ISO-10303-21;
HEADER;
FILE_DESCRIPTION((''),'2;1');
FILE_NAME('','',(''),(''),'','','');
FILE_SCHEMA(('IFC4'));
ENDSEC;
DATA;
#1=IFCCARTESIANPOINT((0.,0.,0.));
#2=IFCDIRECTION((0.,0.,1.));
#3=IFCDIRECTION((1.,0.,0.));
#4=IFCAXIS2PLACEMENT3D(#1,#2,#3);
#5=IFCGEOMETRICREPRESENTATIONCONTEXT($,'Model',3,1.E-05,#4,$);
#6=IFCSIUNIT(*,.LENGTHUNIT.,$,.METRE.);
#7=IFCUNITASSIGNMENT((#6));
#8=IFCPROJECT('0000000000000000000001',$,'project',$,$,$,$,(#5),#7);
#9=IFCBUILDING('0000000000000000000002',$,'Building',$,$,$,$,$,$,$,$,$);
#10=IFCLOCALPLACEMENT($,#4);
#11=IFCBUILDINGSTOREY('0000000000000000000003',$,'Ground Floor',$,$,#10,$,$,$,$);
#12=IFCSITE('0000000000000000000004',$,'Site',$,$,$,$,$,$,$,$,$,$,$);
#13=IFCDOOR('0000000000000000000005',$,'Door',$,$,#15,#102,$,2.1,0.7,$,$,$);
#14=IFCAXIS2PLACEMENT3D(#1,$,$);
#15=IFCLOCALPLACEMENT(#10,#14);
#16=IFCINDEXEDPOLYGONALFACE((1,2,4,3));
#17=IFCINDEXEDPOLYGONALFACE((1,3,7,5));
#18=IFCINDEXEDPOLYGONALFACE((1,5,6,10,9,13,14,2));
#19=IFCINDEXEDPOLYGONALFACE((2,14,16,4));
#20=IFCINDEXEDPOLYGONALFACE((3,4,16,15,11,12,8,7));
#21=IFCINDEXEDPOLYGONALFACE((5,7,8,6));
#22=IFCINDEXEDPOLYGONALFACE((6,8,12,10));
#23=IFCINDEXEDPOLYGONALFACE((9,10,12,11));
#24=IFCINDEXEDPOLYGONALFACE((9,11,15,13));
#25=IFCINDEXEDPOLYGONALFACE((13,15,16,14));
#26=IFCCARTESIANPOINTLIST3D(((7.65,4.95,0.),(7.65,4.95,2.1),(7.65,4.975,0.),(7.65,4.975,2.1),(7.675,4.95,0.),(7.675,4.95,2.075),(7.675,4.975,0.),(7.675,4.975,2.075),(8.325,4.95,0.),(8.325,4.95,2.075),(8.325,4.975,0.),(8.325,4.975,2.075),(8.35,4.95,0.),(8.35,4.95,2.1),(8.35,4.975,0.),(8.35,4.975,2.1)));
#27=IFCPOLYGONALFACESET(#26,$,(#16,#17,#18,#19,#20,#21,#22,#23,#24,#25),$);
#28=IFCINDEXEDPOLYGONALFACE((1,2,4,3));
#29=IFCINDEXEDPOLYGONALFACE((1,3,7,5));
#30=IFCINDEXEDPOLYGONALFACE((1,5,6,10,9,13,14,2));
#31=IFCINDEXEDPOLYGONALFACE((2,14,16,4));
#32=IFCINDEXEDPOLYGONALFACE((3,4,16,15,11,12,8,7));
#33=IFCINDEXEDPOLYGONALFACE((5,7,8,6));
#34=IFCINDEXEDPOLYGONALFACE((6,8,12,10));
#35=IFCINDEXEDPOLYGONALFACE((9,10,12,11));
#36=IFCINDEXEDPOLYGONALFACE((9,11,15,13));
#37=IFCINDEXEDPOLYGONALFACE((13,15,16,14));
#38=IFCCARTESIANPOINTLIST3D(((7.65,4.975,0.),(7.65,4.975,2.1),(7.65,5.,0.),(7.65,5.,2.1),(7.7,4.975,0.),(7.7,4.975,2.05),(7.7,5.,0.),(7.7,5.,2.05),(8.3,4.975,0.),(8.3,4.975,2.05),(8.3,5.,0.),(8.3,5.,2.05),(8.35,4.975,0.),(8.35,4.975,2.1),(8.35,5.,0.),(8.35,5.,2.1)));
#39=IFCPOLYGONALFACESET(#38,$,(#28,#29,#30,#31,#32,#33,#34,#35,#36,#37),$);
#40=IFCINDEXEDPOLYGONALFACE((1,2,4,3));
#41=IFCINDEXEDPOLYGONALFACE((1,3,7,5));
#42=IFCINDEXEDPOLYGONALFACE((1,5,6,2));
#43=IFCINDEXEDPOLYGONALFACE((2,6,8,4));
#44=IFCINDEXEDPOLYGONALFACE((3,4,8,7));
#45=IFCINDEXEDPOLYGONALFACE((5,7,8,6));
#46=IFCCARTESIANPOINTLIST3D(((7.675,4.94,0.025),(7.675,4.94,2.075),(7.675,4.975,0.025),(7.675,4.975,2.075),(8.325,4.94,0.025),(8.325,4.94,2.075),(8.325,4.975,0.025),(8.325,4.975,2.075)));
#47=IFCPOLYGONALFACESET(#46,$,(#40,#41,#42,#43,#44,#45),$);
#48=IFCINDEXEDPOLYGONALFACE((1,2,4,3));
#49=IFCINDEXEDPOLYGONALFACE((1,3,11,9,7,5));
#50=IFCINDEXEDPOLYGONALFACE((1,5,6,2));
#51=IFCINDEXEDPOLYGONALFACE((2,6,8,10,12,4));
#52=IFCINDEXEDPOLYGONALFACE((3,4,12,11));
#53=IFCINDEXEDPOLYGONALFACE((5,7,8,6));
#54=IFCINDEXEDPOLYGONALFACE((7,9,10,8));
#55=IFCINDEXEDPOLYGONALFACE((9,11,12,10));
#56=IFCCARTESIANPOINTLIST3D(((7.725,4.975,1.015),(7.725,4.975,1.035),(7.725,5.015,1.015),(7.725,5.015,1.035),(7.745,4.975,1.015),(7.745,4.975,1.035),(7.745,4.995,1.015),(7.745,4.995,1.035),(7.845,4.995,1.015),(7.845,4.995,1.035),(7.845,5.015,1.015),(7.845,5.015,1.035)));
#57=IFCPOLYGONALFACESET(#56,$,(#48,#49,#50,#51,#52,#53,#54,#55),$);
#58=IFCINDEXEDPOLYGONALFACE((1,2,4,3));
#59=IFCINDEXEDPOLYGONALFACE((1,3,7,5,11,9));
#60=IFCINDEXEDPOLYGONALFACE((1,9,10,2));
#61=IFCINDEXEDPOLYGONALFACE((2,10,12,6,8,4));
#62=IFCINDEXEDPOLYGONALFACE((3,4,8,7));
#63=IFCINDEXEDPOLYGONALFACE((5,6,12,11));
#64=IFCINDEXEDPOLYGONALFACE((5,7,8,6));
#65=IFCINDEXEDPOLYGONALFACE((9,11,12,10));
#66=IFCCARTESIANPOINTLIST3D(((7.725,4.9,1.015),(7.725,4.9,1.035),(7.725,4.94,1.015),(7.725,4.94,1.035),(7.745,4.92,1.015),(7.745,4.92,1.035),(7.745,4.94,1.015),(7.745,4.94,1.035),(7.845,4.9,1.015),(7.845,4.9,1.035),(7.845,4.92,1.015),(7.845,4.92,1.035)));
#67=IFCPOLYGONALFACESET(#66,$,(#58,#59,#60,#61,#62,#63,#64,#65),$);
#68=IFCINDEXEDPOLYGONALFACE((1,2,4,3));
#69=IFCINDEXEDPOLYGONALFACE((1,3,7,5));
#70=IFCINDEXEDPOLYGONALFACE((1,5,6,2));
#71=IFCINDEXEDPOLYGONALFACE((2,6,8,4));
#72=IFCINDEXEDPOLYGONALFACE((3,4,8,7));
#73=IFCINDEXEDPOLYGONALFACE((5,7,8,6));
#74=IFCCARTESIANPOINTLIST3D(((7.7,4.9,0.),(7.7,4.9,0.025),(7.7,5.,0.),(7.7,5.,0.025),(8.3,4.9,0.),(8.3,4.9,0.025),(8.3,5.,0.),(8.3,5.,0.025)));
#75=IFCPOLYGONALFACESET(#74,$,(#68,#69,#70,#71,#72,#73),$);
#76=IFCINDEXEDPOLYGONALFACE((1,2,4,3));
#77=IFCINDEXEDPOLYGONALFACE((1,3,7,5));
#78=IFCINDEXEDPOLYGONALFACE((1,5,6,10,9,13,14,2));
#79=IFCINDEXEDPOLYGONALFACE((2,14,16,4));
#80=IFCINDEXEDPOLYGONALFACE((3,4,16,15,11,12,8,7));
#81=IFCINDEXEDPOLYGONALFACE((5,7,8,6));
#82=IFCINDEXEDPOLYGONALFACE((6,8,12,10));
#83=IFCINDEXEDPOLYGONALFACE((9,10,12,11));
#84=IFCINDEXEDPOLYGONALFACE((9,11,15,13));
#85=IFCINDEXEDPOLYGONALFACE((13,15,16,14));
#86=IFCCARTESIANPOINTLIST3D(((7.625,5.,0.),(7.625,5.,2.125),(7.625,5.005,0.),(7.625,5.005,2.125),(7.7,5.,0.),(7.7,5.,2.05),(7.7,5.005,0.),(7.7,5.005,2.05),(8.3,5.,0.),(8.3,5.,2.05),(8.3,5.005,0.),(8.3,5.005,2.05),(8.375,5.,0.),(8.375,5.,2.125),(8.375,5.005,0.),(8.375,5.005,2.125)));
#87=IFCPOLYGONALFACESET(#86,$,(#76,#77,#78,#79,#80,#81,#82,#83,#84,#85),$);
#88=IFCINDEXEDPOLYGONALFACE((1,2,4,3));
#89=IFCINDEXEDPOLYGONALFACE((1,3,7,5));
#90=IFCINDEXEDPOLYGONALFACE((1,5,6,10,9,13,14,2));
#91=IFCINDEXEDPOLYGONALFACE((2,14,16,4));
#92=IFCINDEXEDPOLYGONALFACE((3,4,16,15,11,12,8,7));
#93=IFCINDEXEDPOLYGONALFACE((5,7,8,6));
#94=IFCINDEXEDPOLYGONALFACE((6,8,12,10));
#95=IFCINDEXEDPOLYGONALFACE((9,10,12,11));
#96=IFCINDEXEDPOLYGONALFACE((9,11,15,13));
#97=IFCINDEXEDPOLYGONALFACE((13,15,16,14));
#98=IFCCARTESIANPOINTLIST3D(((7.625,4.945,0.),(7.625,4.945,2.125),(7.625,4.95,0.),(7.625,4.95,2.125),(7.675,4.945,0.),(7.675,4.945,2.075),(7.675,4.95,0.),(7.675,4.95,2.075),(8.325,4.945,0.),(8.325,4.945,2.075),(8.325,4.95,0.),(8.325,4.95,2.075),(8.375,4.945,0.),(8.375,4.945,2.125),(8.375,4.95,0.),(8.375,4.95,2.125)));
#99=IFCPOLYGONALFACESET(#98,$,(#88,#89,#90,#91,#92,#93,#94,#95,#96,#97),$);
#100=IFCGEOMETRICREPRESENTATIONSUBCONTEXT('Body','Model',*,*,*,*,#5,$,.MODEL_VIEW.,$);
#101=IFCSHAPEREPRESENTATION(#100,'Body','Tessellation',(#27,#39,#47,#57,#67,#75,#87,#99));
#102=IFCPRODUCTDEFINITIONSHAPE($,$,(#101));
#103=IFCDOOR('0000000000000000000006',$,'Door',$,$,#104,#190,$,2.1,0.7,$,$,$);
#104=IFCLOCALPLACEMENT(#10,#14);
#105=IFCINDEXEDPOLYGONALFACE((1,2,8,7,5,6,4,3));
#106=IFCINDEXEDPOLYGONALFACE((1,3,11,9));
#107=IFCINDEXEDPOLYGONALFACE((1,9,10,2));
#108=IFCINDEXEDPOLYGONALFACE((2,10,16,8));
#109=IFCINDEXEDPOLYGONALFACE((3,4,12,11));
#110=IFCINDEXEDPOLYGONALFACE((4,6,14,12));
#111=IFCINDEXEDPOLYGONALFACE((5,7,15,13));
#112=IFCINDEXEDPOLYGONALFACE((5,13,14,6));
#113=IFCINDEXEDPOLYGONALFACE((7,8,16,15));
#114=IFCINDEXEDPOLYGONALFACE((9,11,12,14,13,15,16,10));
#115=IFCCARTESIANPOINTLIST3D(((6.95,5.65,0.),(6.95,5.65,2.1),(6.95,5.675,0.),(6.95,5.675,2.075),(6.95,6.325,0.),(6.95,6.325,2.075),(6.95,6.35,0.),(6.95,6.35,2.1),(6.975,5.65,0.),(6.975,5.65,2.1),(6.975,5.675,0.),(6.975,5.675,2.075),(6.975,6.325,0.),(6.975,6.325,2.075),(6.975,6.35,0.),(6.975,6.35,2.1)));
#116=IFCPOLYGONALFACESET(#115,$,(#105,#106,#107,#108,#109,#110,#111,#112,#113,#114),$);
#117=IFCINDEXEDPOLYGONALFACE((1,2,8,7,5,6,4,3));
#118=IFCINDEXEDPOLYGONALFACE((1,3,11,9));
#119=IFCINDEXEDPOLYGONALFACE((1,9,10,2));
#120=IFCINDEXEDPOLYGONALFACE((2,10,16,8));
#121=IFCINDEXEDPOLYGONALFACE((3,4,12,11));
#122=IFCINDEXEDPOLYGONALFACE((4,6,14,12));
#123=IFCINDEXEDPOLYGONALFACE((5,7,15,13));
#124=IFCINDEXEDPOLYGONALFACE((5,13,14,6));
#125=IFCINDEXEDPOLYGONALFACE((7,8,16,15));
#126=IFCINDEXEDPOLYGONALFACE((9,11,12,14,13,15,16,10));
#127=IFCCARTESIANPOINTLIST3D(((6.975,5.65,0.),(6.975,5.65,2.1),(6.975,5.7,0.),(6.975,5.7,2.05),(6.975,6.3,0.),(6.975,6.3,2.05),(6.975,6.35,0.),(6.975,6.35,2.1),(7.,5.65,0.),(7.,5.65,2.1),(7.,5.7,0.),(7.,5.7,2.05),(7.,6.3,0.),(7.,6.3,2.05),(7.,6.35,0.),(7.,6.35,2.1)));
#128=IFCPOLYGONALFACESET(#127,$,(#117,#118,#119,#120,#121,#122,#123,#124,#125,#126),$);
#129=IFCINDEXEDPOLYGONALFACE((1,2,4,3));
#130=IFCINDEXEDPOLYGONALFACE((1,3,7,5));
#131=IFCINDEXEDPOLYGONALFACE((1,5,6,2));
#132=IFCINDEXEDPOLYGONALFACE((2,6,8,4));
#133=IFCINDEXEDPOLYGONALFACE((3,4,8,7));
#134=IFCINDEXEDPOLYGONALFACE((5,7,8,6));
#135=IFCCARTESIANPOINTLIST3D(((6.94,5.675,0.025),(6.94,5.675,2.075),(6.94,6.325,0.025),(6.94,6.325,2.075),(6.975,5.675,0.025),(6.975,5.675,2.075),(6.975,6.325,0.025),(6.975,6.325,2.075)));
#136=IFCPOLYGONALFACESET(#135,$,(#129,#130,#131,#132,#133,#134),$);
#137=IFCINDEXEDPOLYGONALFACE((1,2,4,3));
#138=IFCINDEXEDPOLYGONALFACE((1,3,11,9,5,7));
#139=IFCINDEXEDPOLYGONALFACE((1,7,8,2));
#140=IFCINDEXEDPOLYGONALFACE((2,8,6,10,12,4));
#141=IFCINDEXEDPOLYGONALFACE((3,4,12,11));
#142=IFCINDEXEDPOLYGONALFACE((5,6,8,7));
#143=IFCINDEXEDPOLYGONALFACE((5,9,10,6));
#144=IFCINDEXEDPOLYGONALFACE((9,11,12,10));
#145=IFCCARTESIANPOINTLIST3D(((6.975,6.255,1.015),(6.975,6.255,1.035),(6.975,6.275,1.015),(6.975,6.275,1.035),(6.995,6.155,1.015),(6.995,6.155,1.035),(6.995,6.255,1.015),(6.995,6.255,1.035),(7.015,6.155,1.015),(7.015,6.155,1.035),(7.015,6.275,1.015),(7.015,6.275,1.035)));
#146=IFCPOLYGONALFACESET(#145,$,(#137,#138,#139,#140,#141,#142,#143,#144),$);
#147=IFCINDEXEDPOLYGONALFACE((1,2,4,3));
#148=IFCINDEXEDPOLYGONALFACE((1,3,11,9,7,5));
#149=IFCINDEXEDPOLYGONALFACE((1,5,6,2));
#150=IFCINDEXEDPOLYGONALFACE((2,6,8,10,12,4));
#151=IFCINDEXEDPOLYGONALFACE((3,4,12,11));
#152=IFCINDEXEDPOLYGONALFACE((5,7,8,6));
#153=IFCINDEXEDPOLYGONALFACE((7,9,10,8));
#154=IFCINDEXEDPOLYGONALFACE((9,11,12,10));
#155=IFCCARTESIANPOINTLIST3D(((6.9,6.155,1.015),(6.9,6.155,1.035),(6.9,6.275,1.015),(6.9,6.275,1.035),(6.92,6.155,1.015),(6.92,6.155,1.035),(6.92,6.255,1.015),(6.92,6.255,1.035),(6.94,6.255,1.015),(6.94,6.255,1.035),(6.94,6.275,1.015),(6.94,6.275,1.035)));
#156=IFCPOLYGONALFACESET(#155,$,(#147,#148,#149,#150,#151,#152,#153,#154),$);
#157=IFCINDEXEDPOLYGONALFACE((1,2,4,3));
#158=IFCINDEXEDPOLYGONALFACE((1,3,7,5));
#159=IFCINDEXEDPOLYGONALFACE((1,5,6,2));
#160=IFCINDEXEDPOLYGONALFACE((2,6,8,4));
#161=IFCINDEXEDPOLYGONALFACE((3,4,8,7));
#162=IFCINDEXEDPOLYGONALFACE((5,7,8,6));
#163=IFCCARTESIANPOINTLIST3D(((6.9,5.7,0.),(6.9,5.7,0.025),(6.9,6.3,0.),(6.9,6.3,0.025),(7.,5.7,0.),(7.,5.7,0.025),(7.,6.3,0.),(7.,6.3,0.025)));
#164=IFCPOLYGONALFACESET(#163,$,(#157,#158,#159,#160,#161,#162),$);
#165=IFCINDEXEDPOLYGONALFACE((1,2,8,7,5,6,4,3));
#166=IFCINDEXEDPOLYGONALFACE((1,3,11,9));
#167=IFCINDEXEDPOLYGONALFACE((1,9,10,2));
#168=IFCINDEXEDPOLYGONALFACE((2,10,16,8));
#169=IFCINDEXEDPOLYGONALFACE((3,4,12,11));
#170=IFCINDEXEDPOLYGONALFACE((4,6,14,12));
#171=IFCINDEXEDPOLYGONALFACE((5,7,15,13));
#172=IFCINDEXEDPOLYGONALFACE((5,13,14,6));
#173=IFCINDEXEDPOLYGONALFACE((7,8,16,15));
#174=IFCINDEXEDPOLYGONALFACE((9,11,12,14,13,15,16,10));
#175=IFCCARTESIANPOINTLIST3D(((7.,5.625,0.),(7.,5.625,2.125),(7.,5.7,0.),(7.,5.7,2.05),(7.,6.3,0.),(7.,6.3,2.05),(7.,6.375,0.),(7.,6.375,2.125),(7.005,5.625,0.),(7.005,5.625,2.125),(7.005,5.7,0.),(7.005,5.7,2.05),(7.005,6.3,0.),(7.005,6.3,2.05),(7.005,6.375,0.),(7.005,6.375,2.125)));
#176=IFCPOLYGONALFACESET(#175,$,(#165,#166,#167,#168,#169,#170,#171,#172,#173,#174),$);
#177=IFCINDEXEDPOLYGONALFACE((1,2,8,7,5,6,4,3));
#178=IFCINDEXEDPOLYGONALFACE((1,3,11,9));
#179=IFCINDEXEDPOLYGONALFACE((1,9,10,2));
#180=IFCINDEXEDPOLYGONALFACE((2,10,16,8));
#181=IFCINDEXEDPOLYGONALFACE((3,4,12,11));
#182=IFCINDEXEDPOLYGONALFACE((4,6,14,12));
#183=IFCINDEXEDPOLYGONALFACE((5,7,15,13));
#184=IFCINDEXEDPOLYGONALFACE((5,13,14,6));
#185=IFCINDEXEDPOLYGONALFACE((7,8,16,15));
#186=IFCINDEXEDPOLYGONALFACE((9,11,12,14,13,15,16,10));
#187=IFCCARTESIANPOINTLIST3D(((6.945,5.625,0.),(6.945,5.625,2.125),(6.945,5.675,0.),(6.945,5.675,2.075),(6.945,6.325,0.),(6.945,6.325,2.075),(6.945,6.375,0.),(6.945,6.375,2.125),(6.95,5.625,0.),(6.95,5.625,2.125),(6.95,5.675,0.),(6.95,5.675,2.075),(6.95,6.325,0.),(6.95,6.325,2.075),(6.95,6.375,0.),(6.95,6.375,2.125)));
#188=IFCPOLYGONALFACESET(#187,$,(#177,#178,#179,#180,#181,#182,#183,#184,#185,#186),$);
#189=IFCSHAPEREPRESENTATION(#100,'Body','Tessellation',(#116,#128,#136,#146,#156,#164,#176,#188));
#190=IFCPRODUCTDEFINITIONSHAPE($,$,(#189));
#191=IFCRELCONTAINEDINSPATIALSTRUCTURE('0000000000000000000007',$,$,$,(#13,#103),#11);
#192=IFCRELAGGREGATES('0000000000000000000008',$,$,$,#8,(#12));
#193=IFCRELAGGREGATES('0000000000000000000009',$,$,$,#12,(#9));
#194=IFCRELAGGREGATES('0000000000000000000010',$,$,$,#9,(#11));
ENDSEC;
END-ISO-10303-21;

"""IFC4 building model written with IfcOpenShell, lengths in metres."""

from ifc_helpers import new_model, si_unit, frame, origin_with_axes, place, context, subcontext, project, spatial, line, indexed_curve, outline, extrude, element, save


model = new_model("IFC4")

# Units and contexts
model_context = context("Model", 3, precision=1e-05, world=origin_with_axes())
body_context = subcontext(model_context, "Body", "Model", "MODEL_VIEW")
ifc_project = project(units=[si_unit("LENGTHUNIT", "METRE")], contexts=[model_context])

# Site, building, storey
site = spatial("IfcSite", under=ifc_project, Name="Site")
building = spatial("IfcBuilding", under=site, Name="Building")
storey_placement = place(None, origin_with_axes())
storey = spatial("IfcBuildingStorey", under=building, at=storey_placement, Name="Ground Floor")

# Doors
door_1_placement = place(storey_placement, frame((8.35, 5.0, 0.0), z_axis=(0.0, 0.0, 1.0), x_axis=(-1.0, 0.0, 0.0)))
element("IfcDoor", 1, at=door_1_placement, inside=storey, Name="Door", OverallHeight=2.1, OverallWidth=0.7, context=body_context, shape_type="SweptSolid", body=[
    extrude(outline(indexed_curve([(0.0, 0.0), (0.0, 2.1), (0.7, 2.1), (0.7, 0.0), (0.675, 0.0), (0.675, 2.075), (0.025, 2.075), (0.025, 0.0)], segments=[line(1, 2, 3, 4, 5, 6, 7, 8, 1)])), frame((0.0, 0.025, 0.0), z_axis=(0.0, -1.0, 0.0), x_axis=(1.0, 0.0, 0.0)), (0.0, 0.0, -1.0), 0.025),
    extrude(outline(indexed_curve([(0.0, 0.0), (0.0, 2.1), (0.7, 2.1), (0.7, 0.0), (0.65, 0.0), (0.65, 2.05), (0.05, 2.05), (0.05, 0.0)], segments=[line(1, 2, 3, 4, 5, 6, 7, 8, 1)])), frame((0.0, 0.0, 0.0), z_axis=(0.0, -1.0, 0.0), x_axis=(1.0, 0.0, 0.0)), (0.0, 0.0, -1.0), 0.025),
    extrude(outline(indexed_curve([(0.0, 0.0), (0.65, 0.0), (0.65, 0.035), (0.0, 0.035)], segments=[line(1, 2, 3, 4, 1)])), frame((0.025, 0.025, 0.025), z_axis=(0.0, 0.0, 1.0), x_axis=(1.0, 0.0, 0.0)), (0.0, 0.0, 1.0), 2.05),
    extrude(outline(indexed_curve([(0.0, 0.0), (0.0, -0.04), (-0.12, -0.04), (-0.12, -0.02), (-0.02, -0.02), (-0.02, 0.0)], segments=[line(1, 2, 3, 4, 5, 6, 1)])), frame((0.625, 0.025, 1.015), z_axis=(0.0, 0.0, 1.0), x_axis=(1.0, 0.0, 0.0)), (0.0, 0.0, 1.0), 0.02),
    extrude(outline(indexed_curve([(0.0, 0.0), (0.0, 0.04), (-0.12, 0.04), (-0.12, 0.02), (-0.02, 0.02), (-0.02, 0.0)], segments=[line(1, 2, 3, 4, 5, 6, 1)])), frame((0.625, 0.06, 1.015), z_axis=(0.0, 0.0, 1.0), x_axis=(1.0, 0.0, 0.0)), (0.0, 0.0, 1.0), 0.02),
    extrude(outline(indexed_curve([(0.0, 0.0), (0.6, 0.0), (0.6, 0.1), (0.0, 0.1)], segments=[line(1, 2, 3, 4, 1)])), frame((0.05, 0.0, 0.0), z_axis=(0.0, 0.0, 1.0), x_axis=(1.0, 0.0, 0.0)), (0.0, 0.0, 1.0), 0.025),
    extrude(outline(indexed_curve([(0.0, 0.0), (0.0, 2.125), (0.75, 2.125), (0.75, 0.0), (0.675, 0.0), (0.675, 2.05), (0.075, 2.05), (0.075, 0.0)], segments=[line(1, 2, 3, 4, 5, 6, 7, 8, 1)])), frame((-0.025, -0.005, 0.0), z_axis=(0.0, -1.0, 0.0), x_axis=(1.0, 0.0, 0.0)), (0.0, 0.0, -1.0), 0.005),
    extrude(outline(indexed_curve([(0.0, 0.0), (0.0, 2.125), (0.75, 2.125), (0.75, 0.0), (0.7, 0.0), (0.7, 2.075), (0.05, 2.075), (0.05, 0.0)], segments=[line(1, 2, 3, 4, 5, 6, 7, 8, 1)])), frame((-0.025, 0.05, 0.0), z_axis=(0.0, -1.0, 0.0), x_axis=(1.0, 0.0, 0.0)), (0.0, 0.0, -1.0), 0.005),
])
door_2_placement = place(storey_placement, frame((7.0, 5.65, 0.0), z_axis=(0.0, 0.0, 1.0), x_axis=(0.0, 1.0, 0.0)))
element("IfcDoor", 2, at=door_2_placement, inside=storey, Name="Door", OverallHeight=2.1, OverallWidth=0.7, context=body_context, shape_type="SweptSolid", body=[
    extrude(outline(indexed_curve([(0.0, 0.0), (0.0, 2.1), (0.7, 2.1), (0.7, 0.0), (0.675, 0.0), (0.675, 2.075), (0.025, 2.075), (0.025, 0.0)], segments=[line(1, 2, 3, 4, 5, 6, 7, 8, 1)])), frame((0.0, 0.025, 0.0), z_axis=(0.0, -1.0, 0.0), x_axis=(1.0, 0.0, 0.0)), (0.0, 0.0, -1.0), 0.025),
    extrude(outline(indexed_curve([(0.0, 0.0), (0.0, 2.1), (0.7, 2.1), (0.7, 0.0), (0.65, 0.0), (0.65, 2.05), (0.05, 2.05), (0.05, 0.0)], segments=[line(1, 2, 3, 4, 5, 6, 7, 8, 1)])), frame((0.0, 0.0, 0.0), z_axis=(0.0, -1.0, 0.0), x_axis=(1.0, 0.0, 0.0)), (0.0, 0.0, -1.0), 0.025),
    extrude(outline(indexed_curve([(0.0, 0.0), (0.65, 0.0), (0.65, 0.035), (0.0, 0.035)], segments=[line(1, 2, 3, 4, 1)])), frame((0.025, 0.025, 0.025), z_axis=(0.0, 0.0, 1.0), x_axis=(1.0, 0.0, 0.0)), (0.0, 0.0, 1.0), 2.05),
    extrude(outline(indexed_curve([(0.0, 0.0), (0.0, -0.04), (-0.12, -0.04), (-0.12, -0.02), (-0.02, -0.02), (-0.02, 0.0)], segments=[line(1, 2, 3, 4, 5, 6, 1)])), frame((0.625, 0.025, 1.015), z_axis=(0.0, 0.0, 1.0), x_axis=(1.0, 0.0, 0.0)), (0.0, 0.0, 1.0), 0.02),
    extrude(outline(indexed_curve([(0.0, 0.0), (0.0, 0.04), (-0.12, 0.04), (-0.12, 0.02), (-0.02, 0.02), (-0.02, 0.0)], segments=[line(1, 2, 3, 4, 5, 6, 1)])), frame((0.625, 0.06, 1.015), z_axis=(0.0, 0.0, 1.0), x_axis=(1.0, 0.0, 0.0)), (0.0, 0.0, 1.0), 0.02),
    extrude(outline(indexed_curve([(0.0, 0.0), (0.6, 0.0), (0.6, 0.1), (0.0, 0.1)], segments=[line(1, 2, 3, 4, 1)])), frame((0.05, 0.0, 0.0), z_axis=(0.0, 0.0, 1.0), x_axis=(1.0, 0.0, 0.0)), (0.0, 0.0, 1.0), 0.025),
    extrude(outline(indexed_curve([(0.0, 0.0), (0.0, 2.125), (0.75, 2.125), (0.75, 0.0), (0.675, 0.0), (0.675, 2.05), (0.075, 2.05), (0.075, 0.0)], segments=[line(1, 2, 3, 4, 5, 6, 7, 8, 1)])), frame((-0.025, -0.005, 0.0), z_axis=(0.0, -1.0, 0.0), x_axis=(1.0, 0.0, 0.0)), (0.0, 0.0, -1.0), 0.005),
    extrude(outline(indexed_curve([(0.0, 0.0), (0.0, 2.125), (0.75, 2.125), (0.75, 0.0), (0.7, 0.0), (0.7, 2.075), (0.05, 2.075), (0.05, 0.0)], segments=[line(1, 2, 3, 4, 5, 6, 7, 8, 1)])), frame((-0.025, 0.05, 0.0), z_axis=(0.0, -1.0, 0.0), x_axis=(1.0, 0.0, 0.0)), (0.0, 0.0, -1.0), 0.005),
])

save(model, "model.ifc")
